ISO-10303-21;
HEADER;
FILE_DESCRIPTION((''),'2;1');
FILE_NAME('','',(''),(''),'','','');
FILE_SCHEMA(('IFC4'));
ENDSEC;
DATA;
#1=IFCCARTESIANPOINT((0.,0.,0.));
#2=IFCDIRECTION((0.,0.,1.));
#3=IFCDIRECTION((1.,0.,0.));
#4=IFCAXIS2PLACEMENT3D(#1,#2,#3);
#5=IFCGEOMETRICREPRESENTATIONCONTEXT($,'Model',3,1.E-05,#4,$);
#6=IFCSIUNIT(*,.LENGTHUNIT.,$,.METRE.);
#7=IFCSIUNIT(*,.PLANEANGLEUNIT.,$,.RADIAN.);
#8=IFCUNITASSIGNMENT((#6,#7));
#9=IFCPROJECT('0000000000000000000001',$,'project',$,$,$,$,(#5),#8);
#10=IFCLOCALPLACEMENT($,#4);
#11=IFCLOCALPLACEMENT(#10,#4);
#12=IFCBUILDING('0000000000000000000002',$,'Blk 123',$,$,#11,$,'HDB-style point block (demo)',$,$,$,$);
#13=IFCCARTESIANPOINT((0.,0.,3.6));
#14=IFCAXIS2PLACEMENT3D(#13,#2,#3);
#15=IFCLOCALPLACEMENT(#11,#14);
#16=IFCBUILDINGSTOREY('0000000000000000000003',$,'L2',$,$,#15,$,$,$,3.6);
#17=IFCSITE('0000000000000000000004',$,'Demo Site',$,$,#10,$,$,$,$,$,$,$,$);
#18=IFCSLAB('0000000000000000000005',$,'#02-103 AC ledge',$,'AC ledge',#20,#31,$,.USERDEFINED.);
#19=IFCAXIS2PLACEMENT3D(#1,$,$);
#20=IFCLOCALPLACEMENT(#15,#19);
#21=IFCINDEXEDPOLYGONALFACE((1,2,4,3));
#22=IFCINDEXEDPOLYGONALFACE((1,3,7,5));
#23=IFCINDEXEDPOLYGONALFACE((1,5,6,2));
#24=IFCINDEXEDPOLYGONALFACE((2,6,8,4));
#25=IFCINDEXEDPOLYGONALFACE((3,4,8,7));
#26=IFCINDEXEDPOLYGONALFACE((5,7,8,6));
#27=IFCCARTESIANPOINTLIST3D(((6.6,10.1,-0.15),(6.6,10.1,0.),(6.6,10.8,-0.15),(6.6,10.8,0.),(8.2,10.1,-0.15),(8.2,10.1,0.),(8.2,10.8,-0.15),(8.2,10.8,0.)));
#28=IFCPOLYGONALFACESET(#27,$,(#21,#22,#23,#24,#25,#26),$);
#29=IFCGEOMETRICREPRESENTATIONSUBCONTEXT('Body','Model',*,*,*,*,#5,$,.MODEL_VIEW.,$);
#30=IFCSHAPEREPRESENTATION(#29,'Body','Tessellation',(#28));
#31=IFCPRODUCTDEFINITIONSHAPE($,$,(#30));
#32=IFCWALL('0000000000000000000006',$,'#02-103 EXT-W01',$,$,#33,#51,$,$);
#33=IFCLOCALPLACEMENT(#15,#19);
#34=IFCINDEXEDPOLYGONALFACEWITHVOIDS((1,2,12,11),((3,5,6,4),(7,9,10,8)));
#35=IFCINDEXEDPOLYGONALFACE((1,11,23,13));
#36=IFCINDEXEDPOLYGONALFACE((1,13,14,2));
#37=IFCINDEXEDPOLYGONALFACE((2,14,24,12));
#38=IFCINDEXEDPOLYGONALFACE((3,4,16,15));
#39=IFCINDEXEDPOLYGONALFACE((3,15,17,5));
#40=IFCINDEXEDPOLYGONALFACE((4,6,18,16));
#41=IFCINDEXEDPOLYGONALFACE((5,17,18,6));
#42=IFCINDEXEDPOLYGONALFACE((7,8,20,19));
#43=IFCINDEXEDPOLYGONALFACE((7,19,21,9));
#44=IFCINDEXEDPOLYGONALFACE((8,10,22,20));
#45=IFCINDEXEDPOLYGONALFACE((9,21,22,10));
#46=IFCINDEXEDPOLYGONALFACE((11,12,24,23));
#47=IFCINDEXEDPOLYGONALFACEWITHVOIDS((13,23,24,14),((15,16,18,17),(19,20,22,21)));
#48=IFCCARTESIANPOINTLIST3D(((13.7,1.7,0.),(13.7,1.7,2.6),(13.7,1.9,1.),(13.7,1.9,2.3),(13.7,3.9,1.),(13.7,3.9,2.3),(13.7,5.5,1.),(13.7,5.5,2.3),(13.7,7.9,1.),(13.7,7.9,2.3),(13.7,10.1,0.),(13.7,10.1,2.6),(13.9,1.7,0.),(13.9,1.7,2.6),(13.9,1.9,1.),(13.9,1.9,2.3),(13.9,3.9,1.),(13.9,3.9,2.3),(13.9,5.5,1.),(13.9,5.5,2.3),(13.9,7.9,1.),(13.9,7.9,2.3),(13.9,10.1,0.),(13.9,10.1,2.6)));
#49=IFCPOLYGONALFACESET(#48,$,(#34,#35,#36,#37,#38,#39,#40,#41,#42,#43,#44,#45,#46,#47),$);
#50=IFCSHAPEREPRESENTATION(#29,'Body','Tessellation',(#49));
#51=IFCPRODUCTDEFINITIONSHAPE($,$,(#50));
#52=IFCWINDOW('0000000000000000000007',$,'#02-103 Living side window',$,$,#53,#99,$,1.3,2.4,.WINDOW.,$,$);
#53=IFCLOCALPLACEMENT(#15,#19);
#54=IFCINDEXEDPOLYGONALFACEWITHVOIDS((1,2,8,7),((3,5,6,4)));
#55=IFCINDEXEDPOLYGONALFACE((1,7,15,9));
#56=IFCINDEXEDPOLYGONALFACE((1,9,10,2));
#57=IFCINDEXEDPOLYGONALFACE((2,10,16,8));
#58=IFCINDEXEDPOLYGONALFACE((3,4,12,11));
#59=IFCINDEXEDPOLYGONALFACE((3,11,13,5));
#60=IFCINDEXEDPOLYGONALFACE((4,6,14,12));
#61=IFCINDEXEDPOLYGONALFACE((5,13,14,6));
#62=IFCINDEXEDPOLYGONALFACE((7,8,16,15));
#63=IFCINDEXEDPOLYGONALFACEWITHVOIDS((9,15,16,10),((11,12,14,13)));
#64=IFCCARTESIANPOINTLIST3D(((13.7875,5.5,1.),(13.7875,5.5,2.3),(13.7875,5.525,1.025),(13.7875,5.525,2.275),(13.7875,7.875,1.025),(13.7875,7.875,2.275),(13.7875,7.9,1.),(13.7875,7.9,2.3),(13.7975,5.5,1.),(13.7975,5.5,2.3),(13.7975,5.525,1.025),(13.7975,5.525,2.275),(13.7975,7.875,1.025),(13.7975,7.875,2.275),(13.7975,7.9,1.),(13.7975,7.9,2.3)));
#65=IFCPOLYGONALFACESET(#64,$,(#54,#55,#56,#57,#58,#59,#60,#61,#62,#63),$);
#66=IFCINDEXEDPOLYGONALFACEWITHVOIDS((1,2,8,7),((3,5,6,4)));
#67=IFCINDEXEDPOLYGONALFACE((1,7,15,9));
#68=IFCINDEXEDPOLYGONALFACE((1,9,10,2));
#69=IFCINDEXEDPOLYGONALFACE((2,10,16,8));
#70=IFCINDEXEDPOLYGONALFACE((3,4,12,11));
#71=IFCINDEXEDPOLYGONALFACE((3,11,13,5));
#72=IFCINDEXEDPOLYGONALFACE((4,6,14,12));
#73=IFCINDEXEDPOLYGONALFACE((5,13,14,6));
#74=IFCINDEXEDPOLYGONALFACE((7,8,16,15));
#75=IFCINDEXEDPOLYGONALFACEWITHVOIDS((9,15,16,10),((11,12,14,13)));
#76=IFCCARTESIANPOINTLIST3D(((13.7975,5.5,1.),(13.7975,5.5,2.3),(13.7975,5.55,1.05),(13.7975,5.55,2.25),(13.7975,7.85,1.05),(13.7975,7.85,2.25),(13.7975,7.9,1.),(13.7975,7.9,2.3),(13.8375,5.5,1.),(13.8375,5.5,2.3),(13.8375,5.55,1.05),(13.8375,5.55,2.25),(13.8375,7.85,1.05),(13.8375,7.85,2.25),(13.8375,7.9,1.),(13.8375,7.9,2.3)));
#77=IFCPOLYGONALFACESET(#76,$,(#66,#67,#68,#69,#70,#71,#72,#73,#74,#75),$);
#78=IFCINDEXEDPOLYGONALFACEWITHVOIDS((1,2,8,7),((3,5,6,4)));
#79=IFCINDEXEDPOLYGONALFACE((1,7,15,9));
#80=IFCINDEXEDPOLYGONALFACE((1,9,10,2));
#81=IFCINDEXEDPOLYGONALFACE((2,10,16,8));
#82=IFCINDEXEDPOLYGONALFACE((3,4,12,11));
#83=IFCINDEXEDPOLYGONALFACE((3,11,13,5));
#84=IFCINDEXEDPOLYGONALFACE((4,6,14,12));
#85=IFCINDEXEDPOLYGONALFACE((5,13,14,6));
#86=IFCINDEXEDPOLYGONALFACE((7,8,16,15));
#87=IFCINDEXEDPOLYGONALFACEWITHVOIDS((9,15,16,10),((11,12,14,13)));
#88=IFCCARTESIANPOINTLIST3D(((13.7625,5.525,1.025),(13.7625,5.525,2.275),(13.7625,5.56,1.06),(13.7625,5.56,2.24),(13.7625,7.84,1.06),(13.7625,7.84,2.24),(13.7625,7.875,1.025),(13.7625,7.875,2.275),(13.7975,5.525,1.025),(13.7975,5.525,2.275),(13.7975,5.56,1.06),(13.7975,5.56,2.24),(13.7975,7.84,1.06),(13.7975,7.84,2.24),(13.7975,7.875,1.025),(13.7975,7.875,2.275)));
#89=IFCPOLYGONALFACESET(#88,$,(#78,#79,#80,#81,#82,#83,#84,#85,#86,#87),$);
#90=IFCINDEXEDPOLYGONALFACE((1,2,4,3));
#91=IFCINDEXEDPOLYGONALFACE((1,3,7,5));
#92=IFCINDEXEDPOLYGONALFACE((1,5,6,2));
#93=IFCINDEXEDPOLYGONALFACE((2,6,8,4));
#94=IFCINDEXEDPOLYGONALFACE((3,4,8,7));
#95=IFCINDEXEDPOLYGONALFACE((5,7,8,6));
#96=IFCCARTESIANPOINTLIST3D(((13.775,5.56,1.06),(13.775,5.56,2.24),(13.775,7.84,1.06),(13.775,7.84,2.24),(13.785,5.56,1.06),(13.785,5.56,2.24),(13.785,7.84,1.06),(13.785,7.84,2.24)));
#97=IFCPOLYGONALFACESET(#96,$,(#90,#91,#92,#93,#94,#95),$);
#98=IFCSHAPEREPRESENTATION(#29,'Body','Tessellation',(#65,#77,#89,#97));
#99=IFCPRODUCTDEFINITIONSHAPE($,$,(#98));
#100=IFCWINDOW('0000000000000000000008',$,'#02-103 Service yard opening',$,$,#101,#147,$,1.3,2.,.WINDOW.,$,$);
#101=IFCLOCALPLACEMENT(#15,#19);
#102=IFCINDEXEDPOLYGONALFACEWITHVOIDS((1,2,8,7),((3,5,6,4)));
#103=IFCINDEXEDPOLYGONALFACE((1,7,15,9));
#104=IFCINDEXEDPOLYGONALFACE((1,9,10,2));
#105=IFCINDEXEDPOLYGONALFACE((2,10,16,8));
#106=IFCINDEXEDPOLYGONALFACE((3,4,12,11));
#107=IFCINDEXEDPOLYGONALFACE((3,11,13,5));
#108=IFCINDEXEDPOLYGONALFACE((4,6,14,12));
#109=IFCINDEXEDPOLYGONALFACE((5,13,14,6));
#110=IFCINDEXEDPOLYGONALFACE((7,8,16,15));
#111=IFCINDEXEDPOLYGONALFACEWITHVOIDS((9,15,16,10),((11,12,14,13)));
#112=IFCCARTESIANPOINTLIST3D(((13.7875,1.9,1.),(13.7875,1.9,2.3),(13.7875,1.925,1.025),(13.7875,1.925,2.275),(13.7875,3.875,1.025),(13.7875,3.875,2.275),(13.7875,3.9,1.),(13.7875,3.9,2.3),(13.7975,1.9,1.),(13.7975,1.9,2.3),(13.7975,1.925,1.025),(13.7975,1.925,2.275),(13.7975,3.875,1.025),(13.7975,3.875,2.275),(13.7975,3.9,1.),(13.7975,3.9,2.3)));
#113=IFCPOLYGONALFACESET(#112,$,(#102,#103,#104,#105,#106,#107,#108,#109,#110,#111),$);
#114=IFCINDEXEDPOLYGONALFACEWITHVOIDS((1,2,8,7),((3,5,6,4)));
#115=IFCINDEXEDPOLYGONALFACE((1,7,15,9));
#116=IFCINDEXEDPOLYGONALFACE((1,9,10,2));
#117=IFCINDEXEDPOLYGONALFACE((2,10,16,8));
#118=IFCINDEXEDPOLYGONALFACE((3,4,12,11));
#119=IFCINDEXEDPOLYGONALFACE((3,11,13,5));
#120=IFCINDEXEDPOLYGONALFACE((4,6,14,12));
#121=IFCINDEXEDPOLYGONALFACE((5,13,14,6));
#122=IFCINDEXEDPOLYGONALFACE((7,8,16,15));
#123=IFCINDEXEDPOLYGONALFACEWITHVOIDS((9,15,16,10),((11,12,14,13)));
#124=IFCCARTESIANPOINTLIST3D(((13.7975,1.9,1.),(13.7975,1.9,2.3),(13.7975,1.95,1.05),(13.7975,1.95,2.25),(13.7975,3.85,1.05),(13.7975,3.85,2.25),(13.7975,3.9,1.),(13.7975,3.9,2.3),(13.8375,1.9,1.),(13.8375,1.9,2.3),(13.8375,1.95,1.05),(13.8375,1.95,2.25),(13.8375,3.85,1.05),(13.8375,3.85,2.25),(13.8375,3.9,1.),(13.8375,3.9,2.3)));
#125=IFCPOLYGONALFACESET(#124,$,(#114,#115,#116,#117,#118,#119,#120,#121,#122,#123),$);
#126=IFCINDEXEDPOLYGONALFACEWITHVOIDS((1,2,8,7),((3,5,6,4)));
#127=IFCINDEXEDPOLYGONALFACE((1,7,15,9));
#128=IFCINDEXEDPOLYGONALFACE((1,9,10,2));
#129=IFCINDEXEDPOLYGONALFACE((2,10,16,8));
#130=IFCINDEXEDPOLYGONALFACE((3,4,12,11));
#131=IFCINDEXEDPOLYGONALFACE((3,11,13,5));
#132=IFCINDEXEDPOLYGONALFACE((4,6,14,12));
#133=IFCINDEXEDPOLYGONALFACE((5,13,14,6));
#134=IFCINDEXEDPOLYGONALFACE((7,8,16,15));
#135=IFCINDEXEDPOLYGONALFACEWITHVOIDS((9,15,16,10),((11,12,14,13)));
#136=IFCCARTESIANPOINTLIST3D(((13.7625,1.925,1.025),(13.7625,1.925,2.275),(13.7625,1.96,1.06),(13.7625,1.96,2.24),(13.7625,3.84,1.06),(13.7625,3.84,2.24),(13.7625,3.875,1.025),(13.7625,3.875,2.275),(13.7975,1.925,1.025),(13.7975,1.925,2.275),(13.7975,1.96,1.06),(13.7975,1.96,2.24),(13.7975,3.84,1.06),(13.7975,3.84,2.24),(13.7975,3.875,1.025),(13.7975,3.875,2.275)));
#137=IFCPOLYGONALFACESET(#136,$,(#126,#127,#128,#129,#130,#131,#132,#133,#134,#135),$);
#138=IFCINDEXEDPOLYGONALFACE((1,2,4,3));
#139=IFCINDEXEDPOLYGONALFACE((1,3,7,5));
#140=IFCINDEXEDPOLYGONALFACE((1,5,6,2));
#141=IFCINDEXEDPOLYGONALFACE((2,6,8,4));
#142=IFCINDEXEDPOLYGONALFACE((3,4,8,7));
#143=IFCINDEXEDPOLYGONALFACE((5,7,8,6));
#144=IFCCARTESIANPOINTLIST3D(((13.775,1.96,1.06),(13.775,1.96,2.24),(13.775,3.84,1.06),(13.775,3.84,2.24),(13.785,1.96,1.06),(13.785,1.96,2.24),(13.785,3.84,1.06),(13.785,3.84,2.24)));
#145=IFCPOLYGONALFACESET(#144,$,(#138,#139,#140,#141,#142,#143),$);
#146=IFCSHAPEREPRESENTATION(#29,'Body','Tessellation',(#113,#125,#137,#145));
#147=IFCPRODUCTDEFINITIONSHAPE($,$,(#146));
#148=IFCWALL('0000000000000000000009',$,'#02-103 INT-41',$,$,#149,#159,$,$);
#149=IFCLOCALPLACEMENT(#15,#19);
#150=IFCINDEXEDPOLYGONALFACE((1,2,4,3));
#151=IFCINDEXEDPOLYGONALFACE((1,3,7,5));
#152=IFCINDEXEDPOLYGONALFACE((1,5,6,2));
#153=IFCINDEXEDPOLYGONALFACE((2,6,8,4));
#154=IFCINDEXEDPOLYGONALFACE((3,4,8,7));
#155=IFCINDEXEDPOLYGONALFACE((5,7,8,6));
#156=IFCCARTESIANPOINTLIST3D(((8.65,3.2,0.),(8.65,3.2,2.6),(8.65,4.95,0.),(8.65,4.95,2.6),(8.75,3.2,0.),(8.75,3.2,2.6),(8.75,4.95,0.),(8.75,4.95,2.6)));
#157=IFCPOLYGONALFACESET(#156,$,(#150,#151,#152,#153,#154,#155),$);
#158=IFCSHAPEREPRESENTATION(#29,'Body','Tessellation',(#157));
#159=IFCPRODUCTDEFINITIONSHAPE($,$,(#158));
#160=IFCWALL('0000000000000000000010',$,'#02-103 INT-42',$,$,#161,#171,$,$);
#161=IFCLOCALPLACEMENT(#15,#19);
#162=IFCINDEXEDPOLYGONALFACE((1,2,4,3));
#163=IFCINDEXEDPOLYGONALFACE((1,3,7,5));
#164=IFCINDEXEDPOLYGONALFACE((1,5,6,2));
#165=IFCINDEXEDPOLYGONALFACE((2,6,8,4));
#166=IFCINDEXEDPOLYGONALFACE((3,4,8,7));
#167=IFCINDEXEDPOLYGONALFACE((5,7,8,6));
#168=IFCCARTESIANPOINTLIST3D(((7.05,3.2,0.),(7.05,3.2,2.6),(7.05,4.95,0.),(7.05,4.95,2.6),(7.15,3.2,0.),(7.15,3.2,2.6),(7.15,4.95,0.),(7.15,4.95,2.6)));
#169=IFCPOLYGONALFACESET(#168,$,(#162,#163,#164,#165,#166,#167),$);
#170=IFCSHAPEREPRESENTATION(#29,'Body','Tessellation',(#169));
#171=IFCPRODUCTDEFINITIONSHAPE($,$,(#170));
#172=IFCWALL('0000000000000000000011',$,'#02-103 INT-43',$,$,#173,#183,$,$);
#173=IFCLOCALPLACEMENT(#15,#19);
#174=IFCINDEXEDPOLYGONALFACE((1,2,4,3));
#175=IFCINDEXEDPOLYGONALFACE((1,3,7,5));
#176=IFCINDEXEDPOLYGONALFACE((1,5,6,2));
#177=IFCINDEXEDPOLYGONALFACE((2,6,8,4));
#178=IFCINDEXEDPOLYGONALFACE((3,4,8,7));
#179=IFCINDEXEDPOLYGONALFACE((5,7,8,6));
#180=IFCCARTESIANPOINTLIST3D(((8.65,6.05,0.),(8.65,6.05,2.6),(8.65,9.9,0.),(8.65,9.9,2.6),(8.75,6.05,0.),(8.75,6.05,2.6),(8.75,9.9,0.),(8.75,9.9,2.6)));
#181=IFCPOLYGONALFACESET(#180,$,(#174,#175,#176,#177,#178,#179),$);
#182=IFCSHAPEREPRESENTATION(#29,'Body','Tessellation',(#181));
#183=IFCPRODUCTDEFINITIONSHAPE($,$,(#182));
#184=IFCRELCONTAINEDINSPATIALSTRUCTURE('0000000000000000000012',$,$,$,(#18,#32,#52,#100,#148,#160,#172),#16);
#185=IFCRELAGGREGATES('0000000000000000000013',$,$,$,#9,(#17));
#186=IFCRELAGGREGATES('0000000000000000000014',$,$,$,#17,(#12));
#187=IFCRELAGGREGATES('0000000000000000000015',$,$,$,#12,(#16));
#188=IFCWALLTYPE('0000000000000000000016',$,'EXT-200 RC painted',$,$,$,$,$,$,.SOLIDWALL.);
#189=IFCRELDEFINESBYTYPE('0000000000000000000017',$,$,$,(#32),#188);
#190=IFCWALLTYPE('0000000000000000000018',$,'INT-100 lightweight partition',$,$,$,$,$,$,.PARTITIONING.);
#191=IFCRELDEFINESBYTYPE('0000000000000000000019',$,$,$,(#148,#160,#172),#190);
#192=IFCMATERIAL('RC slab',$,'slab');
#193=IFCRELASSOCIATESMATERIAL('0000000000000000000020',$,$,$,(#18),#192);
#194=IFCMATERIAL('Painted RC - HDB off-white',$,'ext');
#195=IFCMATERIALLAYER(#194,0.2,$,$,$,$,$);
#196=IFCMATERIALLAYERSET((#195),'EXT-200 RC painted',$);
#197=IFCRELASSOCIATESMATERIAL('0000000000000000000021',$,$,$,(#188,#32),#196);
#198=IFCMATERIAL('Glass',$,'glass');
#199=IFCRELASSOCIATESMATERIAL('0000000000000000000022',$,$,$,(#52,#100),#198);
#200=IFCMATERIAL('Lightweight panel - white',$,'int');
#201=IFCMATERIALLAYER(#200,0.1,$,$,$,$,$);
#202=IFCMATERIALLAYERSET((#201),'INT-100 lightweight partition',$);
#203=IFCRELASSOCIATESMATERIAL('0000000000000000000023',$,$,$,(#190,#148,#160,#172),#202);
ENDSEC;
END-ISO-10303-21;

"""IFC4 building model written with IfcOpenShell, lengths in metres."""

from ifc_helpers import new_model, si_unit, frame, origin, origin_with_axes, place, context, subcontext, project, spatial, polyline, line, indexed_curve, outline, extrude, material, layer, layer_set, layer_usage, type_object, element, fill, save


model = new_model("IFC4")

# Units and contexts
model_context = context("Model", 3, precision=1e-05, world=origin_with_axes())
body_context = subcontext(model_context, "Body", "Model", "MODEL_VIEW")
ifc_project = project(units=[si_unit("LENGTHUNIT", "METRE"), si_unit("PLANEANGLEUNIT", "RADIAN")], contexts=[model_context])

# Site, building, storey
site_placement = place(None, origin_with_axes())
site = spatial("IfcSite", under=ifc_project, at=site_placement, Name="Demo Site")
building_placement = place(site_placement, origin_with_axes())
building = spatial("IfcBuilding", under=site, at=building_placement, Name="Blk 123", LongName="HDB-style point block (demo)")
storey_placement = place(building_placement, frame((0.0, 0.0, 3.6), z_axis=(0.0, 0.0, 1.0), x_axis=(1.0, 0.0, 0.0)))
storey = spatial("IfcBuildingStorey", under=building, at=storey_placement, Name="L2", Elevation=3.6)

# Slab
ifc_material_1 = material(Name="RC slab", Category="slab")
slab_placement = place(storey_placement, frame((7.4, 10.45, -0.15), z_axis=(0.0, 0.0, 1.0), x_axis=(1.0, 0.0, 0.0)))
element("IfcSlab", 1, at=slab_placement, inside=storey, material=ifc_material_1, Name="#02-103 AC ledge", ObjectType="AC ledge", PredefinedType="USERDEFINED", context=body_context, shape_type="SweptSolid", body=[
    extrude(outline(polyline([(0.8, -0.35), (0.8, 0.35), (-0.8, 0.35), (-0.8, -0.35), (0.8, -0.35)])), origin(), (0.0, 0.0, 1.0), 0.15),
])

# Wall, openings, windows
ifc_material_2 = material(Name="Painted RC - HDB off-white", Category="ext")
ifc_layer_1 = layer(ifc_material_2, 0.2)
ifc_layer_set_1 = layer_set([ifc_layer_1], Name="EXT-200 RC painted")
ifc_layer_usage_1 = layer_usage(ifc_layer_set_1, "AXIS2", "POSITIVE", 0.0)
wall_type_1 = type_object("IfcWallType", Name="EXT-200 RC painted", PredefinedType="SOLIDWALL", material=ifc_layer_set_1)
wall_1_placement = place(storey_placement, frame((13.9, 1.7, 0.0), z_axis=(0.0, 0.0, 1.0), x_axis=(0.0, 1.0, 0.0)))
wall_1 = element("IfcWall", 2, at=wall_1_placement, inside=storey, type_object=wall_type_1, material=ifc_layer_usage_1, Name="#02-103 EXT-W01", context=body_context, shape_type="SweptSolid", body=[
    extrude(outline(indexed_curve([(0.0, 0.0), (0.0, 0.2), (8.4, 0.2), (8.4, 0.0), (0.0, 0.0)], self_intersect=False)), origin_with_axes(), (0.0, 0.0, 1.0), 2.6),
])
opening_1_placement = place(wall_1_placement, frame((3.8, -0.1, 1.0), z_axis=(0.0, 0.0, 1.0), x_axis=(1.0, 0.0, 0.0)))
opening_1 = element("IfcOpeningElement", 3, at=opening_1_placement, cuts=wall_1, context=body_context, shape_type="SweptSolid", body=[
    extrude(outline(indexed_curve([(0.0, 0.0), (0.0, 0.4), (2.4, 0.4), (2.4, 0.0), (0.0, 0.0)], self_intersect=False)), origin_with_axes(), (0.0, 0.0, 1.0), 1.3),
])
opening_2_placement = place(wall_1_placement, frame((0.2, -0.1, 1.0), z_axis=(0.0, 0.0, 1.0), x_axis=(1.0, 0.0, 0.0)))
opening_2 = element("IfcOpeningElement", 4, at=opening_2_placement, cuts=wall_1, context=body_context, shape_type="SweptSolid", body=[
    extrude(outline(indexed_curve([(0.0, 0.0), (0.0, 0.4), (2.0, 0.4), (2.0, 0.0), (0.0, 0.0)], self_intersect=False)), origin_with_axes(), (0.0, 0.0, 1.0), 1.3),
])
ifc_material_3 = material(Name="Glass", Category="glass")
window_1_placement = place(opening_1_placement, frame((0.0, 0.1125, 0.0), z_axis=(0.0, 0.0, 1.0), x_axis=(1.0, 0.0, 0.0)))
window_1 = element("IfcWindow", 5, at=window_1_placement, inside=storey, material=ifc_material_3, Name="#02-103 Living side window", OverallHeight=1.3, OverallWidth=2.4, PredefinedType="WINDOW", context=body_context, shape_type="SweptSolid", body=[
    extrude(outline(indexed_curve([(0.0, 0.0), (2.4, 0.0), (2.4, 1.3), (0.0, 1.3)], segments=[line(1, 2, 3, 4, 1)]), holes=[indexed_curve([(0.025, 0.025), (2.375, 0.025), (2.375, 1.275), (0.025, 1.275)], segments=[line(1, 2, 3, 4, 1)])]), frame((0.0, 0.09, 0.0), z_axis=(0.0, -1.0, 0.0), x_axis=(1.0, 0.0, 0.0)), (0.0, 0.0, -1.0), 0.01),
    extrude(outline(indexed_curve([(0.0, 0.0), (2.4, 0.0), (2.4, 1.3), (0.0, 1.3)], segments=[line(1, 2, 3, 4, 1)]), holes=[indexed_curve([(0.05, 0.05), (2.35, 0.05), (2.35, 1.25), (0.05, 1.25)], segments=[line(1, 2, 3, 4, 1)])]), frame((0.0, 0.05, 0.0), z_axis=(0.0, -1.0, 0.0), x_axis=(1.0, 0.0, 0.0)), (0.0, 0.0, -1.0), 0.04),
    extrude(outline(indexed_curve([(0.0, 0.0), (2.35, 0.0), (2.35, 1.25), (0.0, 1.25)], segments=[line(1, 2, 3, 4, 1)]), holes=[indexed_curve([(0.035, 0.035), (2.315, 0.035), (2.315, 1.215), (0.035, 1.215)], segments=[line(1, 2, 3, 4, 1)])]), frame((0.025, 0.09, 0.025), z_axis=(0.0, -1.0, 0.0), x_axis=(1.0, 0.0, 0.0)), (0.0, 0.0, -1.0), 0.035),
    extrude(outline(indexed_curve([(0.035, 0.035), (2.315, 0.035), (2.315, 1.215), (0.035, 1.215)], segments=[line(1, 2, 3, 4, 1)])), frame((0.025, 0.1025, 0.025), z_axis=(0.0, -1.0, 0.0), x_axis=(1.0, 0.0, 0.0)), (0.0, 0.0, -1.0), 0.01),
])
fill(opening_1, window_1)
window_2_placement = place(opening_2_placement, frame((0.0, 0.1125, 0.0), z_axis=(0.0, 0.0, 1.0), x_axis=(1.0, 0.0, 0.0)))
window_2 = element("IfcWindow", 6, at=window_2_placement, inside=storey, material=ifc_material_3, Name="#02-103 Service yard opening", OverallHeight=1.3, OverallWidth=2.0, PredefinedType="WINDOW", context=body_context, shape_type="SweptSolid", body=[
    extrude(outline(indexed_curve([(0.0, 0.0), (2.0, 0.0), (2.0, 1.3), (0.0, 1.3)], segments=[line(1, 2, 3, 4, 1)]), holes=[indexed_curve([(0.025, 0.025), (1.975, 0.025), (1.975, 1.275), (0.025, 1.275)], segments=[line(1, 2, 3, 4, 1)])]), frame((0.0, 0.09, 0.0), z_axis=(0.0, -1.0, 0.0), x_axis=(1.0, 0.0, 0.0)), (0.0, 0.0, -1.0), 0.01),
    extrude(outline(indexed_curve([(0.0, 0.0), (2.0, 0.0), (2.0, 1.3), (0.0, 1.3)], segments=[line(1, 2, 3, 4, 1)]), holes=[indexed_curve([(0.05, 0.05), (1.95, 0.05), (1.95, 1.25), (0.05, 1.25)], segments=[line(1, 2, 3, 4, 1)])]), frame((0.0, 0.05, 0.0), z_axis=(0.0, -1.0, 0.0), x_axis=(1.0, 0.0, 0.0)), (0.0, 0.0, -1.0), 0.04),
    extrude(outline(indexed_curve([(0.0, 0.0), (1.95, 0.0), (1.95, 1.25), (0.0, 1.25)], segments=[line(1, 2, 3, 4, 1)]), holes=[indexed_curve([(0.035, 0.035), (1.915, 0.035), (1.915, 1.215), (0.035, 1.215)], segments=[line(1, 2, 3, 4, 1)])]), frame((0.025, 0.09, 0.025), z_axis=(0.0, -1.0, 0.0), x_axis=(1.0, 0.0, 0.0)), (0.0, 0.0, -1.0), 0.035),
    extrude(outline(indexed_curve([(0.035, 0.035), (1.915, 0.035), (1.915, 1.215), (0.035, 1.215)], segments=[line(1, 2, 3, 4, 1)])), frame((0.025, 0.1025, 0.025), z_axis=(0.0, -1.0, 0.0), x_axis=(1.0, 0.0, 0.0)), (0.0, 0.0, -1.0), 0.01),
])
fill(opening_2, window_2)

# Walls
ifc_material_4 = material(Name="Lightweight panel - white", Category="int")
ifc_layer_2 = layer(ifc_material_4, 0.1)
ifc_layer_set_2 = layer_set([ifc_layer_2], Name="INT-100 lightweight partition")
ifc_layer_usage_2 = layer_usage(ifc_layer_set_2, "AXIS2", "POSITIVE", -0.05)
wall_type_2 = type_object("IfcWallType", Name="INT-100 lightweight partition", PredefinedType="PARTITIONING", material=ifc_layer_set_2)
for number, where, z_axis, x_axis, name in (
    (7, (8.7, 3.2, 0.0), (0.0, 0.0, 1.0), (0.0, 1.0, 0.0), "#02-103 INT-41"),
    (8, (7.1, 3.2, 0.0), (0.0, 0.0, 1.0), (0.0, 1.0, 0.0), "#02-103 INT-42"),
):
    element("IfcWall", number, at=place(storey_placement, frame(where, z_axis=z_axis, x_axis=x_axis)), inside=storey, type_object=wall_type_2, material=ifc_layer_usage_2, Name=name, context=body_context, shape_type="SweptSolid", body=[
        extrude(outline(indexed_curve([(0.0, 0.0), (0.0, 0.1), (1.75, 0.1), (1.75, 0.0), (0.0, 0.0)], self_intersect=False)), frame((0.0, -0.05, 0.0), z_axis=(0.0, 0.0, 1.0), x_axis=(1.0, 0.0, 0.0)), (0.0, 0.0, 1.0), 2.6),
    ])
wall_2_placement = place(storey_placement, frame((8.7, 6.05, 0.0), z_axis=(0.0, 0.0, 1.0), x_axis=(0.0, 1.0, 0.0)))
element("IfcWall", 9, at=wall_2_placement, inside=storey, type_object=wall_type_2, material=ifc_layer_usage_2, Name="#02-103 INT-43", context=body_context, shape_type="SweptSolid", body=[
    extrude(outline(indexed_curve([(0.0, 0.0), (0.0, 0.1), (3.85, 0.1), (3.85, 0.0), (0.0, 0.0)], self_intersect=False)), frame((0.0, -0.05, 0.0), z_axis=(0.0, 0.0, 1.0), x_axis=(1.0, 0.0, 0.0)), (0.0, 0.0, 1.0), 2.6),
])

save(model, "model.ifc")
